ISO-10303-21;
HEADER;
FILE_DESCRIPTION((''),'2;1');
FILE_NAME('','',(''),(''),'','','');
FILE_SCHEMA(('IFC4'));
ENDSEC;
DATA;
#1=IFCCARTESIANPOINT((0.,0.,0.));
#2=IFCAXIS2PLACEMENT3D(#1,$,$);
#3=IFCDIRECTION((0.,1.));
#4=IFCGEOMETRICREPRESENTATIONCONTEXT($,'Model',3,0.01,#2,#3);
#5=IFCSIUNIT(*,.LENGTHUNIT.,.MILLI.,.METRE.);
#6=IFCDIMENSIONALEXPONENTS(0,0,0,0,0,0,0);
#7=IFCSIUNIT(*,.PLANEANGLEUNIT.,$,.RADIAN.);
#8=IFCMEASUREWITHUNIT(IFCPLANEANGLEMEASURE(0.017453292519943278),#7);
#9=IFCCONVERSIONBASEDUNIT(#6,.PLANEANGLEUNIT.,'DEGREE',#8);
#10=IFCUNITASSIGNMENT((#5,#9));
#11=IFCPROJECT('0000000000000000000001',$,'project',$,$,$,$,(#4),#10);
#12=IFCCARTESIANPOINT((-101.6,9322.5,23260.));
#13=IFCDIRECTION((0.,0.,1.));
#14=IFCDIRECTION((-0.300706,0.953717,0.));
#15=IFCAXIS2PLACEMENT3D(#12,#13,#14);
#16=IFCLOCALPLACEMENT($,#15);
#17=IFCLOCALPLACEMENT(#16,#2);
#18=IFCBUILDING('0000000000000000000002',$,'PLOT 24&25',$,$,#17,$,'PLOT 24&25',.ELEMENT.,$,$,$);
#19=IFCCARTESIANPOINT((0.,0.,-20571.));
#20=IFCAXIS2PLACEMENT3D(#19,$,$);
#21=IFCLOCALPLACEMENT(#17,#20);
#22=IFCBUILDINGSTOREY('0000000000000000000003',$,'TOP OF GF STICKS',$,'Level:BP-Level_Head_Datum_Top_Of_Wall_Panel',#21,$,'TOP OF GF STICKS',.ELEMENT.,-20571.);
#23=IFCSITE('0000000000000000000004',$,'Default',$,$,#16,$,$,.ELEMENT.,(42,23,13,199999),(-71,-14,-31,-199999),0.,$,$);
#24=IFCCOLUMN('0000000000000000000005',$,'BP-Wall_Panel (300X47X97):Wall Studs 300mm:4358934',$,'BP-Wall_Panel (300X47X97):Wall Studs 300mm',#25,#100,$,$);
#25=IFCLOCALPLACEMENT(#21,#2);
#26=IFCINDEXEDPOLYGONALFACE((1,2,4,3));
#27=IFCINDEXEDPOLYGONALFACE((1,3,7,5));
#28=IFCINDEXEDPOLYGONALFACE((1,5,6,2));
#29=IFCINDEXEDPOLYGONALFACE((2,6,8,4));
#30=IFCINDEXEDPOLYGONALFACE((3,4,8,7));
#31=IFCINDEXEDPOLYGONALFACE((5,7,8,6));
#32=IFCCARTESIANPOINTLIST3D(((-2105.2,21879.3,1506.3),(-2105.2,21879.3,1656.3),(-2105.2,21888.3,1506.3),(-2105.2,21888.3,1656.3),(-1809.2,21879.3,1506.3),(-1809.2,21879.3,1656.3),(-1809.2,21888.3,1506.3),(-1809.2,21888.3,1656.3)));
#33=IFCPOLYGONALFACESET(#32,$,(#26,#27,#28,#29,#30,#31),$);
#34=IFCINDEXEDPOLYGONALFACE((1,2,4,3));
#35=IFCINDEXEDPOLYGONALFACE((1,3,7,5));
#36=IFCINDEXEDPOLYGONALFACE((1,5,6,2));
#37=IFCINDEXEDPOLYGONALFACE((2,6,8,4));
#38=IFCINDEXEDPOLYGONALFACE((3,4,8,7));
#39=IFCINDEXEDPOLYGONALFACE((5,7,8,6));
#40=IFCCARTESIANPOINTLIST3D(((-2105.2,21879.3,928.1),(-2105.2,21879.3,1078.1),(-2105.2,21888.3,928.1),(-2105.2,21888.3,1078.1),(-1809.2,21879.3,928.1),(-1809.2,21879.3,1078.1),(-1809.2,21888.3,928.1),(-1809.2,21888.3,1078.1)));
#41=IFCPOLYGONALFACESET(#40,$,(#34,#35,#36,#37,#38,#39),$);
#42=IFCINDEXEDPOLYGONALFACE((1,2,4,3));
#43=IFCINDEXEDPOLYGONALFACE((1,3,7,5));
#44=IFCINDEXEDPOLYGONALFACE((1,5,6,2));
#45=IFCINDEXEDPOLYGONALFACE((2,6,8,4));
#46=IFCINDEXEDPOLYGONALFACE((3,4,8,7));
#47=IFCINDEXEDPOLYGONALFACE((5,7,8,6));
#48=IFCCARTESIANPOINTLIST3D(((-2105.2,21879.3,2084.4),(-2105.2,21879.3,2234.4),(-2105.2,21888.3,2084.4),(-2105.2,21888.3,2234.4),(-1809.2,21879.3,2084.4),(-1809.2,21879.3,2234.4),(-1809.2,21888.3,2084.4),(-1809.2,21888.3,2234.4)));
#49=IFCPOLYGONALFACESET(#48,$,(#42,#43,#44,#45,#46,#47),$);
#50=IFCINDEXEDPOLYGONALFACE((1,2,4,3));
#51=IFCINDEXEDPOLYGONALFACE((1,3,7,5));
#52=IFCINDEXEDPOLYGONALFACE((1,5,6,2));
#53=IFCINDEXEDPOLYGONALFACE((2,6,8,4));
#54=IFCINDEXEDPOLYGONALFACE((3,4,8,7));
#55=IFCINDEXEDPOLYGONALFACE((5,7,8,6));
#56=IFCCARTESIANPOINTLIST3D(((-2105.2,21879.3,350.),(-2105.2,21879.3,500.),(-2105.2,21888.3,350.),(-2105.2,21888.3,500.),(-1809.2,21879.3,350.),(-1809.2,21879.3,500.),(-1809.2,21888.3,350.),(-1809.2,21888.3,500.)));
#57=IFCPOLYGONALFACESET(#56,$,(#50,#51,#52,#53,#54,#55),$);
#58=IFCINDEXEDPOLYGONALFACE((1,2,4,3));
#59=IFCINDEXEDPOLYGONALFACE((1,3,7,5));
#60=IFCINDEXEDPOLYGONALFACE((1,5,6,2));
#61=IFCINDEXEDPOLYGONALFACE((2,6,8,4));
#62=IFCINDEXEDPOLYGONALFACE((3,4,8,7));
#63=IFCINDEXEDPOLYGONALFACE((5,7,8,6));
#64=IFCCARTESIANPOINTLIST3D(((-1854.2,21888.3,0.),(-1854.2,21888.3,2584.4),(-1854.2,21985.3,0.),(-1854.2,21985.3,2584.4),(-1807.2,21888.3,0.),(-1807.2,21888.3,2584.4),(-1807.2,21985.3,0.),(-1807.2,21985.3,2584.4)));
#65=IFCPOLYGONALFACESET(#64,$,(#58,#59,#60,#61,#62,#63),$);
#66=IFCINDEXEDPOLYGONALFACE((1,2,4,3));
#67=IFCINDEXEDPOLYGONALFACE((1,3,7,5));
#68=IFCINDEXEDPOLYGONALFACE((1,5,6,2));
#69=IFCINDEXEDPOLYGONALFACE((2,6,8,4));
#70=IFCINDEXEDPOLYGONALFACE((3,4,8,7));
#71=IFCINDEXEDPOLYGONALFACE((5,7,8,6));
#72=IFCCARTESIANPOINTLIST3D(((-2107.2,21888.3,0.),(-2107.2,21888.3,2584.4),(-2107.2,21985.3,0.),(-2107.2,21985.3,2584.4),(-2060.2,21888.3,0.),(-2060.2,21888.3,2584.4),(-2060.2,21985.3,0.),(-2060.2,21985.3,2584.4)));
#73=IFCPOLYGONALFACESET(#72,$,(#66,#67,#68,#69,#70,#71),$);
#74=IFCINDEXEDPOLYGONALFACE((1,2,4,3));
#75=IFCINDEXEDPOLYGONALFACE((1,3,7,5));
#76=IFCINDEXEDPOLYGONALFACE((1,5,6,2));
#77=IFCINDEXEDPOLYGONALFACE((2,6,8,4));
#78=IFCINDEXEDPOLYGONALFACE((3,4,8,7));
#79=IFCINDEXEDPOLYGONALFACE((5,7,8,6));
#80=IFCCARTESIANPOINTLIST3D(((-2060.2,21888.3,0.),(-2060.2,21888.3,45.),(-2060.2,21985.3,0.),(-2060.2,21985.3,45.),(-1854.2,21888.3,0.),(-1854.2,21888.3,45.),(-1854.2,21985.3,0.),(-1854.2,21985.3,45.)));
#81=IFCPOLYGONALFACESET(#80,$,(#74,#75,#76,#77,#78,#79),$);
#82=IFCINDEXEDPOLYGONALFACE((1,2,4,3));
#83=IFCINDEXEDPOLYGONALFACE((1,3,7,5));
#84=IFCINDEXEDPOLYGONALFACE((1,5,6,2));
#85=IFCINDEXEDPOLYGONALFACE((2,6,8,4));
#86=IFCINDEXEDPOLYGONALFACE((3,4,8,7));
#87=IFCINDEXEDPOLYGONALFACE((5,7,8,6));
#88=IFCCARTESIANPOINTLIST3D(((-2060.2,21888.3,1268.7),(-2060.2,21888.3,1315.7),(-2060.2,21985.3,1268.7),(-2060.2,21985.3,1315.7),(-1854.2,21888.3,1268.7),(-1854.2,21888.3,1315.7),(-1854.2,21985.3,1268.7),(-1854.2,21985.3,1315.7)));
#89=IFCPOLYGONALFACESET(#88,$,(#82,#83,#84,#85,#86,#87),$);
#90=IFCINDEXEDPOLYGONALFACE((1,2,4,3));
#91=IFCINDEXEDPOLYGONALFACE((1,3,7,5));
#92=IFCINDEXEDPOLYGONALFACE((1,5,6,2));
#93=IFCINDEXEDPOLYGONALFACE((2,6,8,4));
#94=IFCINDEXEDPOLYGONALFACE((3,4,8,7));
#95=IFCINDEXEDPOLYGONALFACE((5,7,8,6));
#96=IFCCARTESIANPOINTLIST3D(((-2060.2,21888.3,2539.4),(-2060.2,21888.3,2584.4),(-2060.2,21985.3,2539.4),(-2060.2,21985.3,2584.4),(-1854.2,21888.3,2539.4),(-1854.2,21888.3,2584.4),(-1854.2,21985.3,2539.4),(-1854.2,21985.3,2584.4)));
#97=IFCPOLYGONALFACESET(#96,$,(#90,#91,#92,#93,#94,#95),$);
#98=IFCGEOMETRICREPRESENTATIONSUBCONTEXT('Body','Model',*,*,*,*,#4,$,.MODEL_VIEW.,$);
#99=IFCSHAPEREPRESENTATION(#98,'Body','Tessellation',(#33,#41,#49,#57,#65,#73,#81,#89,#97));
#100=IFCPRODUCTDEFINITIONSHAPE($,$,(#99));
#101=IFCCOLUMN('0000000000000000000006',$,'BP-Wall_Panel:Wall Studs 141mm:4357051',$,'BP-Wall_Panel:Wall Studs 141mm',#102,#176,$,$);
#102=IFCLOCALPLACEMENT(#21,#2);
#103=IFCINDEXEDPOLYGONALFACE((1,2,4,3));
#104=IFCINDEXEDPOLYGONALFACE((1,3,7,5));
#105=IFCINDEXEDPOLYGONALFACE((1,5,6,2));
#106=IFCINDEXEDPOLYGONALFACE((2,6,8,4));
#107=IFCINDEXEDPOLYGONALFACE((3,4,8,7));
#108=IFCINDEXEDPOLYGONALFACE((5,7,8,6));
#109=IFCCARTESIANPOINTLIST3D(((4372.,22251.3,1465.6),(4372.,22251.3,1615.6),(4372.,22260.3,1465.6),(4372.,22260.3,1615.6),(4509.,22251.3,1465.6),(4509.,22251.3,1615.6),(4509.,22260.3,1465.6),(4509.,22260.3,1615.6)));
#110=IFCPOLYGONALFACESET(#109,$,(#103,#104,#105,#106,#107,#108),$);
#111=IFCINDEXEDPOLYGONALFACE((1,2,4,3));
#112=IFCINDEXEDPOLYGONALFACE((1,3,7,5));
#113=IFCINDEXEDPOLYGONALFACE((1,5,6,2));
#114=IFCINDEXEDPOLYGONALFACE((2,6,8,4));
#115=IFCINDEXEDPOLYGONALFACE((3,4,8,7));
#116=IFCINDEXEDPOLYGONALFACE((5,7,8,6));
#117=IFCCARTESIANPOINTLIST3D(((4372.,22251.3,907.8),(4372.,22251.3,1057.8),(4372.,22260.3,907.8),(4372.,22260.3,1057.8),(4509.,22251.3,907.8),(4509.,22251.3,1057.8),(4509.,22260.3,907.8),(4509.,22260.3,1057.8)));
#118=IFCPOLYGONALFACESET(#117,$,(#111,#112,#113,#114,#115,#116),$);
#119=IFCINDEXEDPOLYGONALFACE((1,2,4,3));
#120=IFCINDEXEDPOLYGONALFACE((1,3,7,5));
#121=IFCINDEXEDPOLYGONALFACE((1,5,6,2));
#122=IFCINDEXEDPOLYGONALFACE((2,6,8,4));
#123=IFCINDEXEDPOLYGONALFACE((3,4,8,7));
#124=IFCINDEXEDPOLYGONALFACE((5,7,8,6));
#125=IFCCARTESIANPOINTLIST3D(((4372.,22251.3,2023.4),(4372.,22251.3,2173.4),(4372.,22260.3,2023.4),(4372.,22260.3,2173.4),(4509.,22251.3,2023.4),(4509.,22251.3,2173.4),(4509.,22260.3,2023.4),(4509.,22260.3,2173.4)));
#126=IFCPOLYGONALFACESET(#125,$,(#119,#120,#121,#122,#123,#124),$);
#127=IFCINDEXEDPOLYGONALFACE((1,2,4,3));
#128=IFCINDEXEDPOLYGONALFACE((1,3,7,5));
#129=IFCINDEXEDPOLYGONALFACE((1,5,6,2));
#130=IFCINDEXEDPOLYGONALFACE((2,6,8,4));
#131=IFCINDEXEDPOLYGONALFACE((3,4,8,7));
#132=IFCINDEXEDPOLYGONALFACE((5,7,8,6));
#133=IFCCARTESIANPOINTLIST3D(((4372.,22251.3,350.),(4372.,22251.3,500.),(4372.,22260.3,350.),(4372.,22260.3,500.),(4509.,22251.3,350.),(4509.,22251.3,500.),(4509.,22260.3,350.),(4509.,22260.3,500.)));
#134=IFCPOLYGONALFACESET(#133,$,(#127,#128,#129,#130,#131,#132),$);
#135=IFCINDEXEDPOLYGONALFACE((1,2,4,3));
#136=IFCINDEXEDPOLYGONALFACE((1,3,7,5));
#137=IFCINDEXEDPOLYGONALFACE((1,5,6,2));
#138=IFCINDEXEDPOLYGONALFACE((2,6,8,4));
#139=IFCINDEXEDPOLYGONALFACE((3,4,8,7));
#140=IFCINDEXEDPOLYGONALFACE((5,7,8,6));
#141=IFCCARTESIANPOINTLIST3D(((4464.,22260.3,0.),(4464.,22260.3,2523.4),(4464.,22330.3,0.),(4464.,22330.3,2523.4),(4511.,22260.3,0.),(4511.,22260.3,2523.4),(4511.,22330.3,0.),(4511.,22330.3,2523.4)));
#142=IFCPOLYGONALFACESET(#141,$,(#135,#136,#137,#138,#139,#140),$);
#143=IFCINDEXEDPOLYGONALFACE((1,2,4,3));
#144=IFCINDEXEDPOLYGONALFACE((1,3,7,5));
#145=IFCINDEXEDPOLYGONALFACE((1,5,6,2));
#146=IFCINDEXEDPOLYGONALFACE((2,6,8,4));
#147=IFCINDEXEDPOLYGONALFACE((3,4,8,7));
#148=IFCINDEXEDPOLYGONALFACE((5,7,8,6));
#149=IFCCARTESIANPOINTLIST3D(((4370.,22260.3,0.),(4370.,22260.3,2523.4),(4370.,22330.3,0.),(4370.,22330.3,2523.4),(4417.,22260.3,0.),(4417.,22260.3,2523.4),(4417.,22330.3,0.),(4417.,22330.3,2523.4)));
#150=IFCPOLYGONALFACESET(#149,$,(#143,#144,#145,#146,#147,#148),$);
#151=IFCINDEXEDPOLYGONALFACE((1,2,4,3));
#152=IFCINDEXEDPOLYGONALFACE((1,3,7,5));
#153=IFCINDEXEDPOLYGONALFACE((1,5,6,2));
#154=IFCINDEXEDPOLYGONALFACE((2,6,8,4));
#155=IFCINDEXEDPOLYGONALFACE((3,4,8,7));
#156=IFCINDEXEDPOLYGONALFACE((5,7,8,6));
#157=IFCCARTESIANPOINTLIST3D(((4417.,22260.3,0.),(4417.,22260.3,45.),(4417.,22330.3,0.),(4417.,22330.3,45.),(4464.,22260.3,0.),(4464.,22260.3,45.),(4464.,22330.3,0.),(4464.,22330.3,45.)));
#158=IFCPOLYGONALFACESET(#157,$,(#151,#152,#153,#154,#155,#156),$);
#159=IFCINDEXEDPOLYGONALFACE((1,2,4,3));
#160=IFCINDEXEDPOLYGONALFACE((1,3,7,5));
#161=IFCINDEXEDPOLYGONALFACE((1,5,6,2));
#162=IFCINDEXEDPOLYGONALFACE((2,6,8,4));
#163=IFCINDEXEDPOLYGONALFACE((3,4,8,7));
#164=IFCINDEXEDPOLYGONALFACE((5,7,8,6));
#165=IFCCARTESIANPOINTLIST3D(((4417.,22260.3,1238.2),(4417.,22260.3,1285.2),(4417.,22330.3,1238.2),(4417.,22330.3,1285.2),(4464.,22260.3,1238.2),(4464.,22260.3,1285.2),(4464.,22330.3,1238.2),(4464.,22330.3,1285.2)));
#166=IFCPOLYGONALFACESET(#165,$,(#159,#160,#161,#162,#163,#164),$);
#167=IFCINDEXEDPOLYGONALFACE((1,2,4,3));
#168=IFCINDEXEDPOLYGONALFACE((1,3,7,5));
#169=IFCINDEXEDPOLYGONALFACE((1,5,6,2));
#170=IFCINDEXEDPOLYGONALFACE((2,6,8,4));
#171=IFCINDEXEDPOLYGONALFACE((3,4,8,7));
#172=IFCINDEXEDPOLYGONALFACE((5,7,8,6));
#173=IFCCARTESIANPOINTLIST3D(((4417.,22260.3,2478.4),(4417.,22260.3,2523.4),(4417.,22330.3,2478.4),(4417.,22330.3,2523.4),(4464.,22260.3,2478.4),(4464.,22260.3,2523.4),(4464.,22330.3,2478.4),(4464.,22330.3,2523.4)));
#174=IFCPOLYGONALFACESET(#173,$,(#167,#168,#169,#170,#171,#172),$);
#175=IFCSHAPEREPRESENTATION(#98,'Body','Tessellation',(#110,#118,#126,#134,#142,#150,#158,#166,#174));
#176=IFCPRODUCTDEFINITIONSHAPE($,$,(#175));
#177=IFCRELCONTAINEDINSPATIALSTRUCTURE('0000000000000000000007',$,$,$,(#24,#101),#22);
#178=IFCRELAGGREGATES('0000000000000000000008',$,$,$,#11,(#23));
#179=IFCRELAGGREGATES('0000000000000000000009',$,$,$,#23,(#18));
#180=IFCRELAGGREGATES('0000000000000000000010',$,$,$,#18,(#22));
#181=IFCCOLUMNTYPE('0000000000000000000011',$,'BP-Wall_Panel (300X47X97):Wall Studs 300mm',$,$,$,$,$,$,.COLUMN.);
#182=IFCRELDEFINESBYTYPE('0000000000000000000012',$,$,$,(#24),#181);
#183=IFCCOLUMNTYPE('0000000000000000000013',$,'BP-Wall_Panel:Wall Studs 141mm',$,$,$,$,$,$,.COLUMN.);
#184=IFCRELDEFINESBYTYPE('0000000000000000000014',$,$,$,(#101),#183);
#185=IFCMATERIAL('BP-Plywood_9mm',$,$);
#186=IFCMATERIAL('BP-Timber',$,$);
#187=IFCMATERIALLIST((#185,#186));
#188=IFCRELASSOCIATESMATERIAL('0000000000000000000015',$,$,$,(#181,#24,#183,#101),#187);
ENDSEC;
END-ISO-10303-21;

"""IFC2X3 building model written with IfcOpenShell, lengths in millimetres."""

from ifc_helpers import new_model, entity, si_unit, converted_unit, direction, frame, frame_2d, origin, origin_2d_with_axis, place, context, subcontext, project, spatial, rectangle, extrude, source, transform, mapped, material, material_list, type_object, type_shapes, element, save


model = new_model("IFC2X3")

# Units and contexts
model_context = context("Model", 3, precision=0.01, world=origin(), true_north=direction((0.0, 1.0)))
body_context = subcontext(model_context, "Body", "Model", "MODEL_VIEW")
ifc_project = project(units=[si_unit("LENGTHUNIT", "METRE", prefix="MILLI"), converted_unit("PLANEANGLEUNIT", "DEGREE", entity("IfcPlaneAngleMeasure", 0.017453292519943278), si_unit("PLANEANGLEUNIT", "RADIAN"), dimensions=[0, 0, 0, 0, 0, 0, 0])], contexts=[model_context])

# Site, building, storey
site_placement = place(None, frame((-101.6, 9322.5, 23260.0), z_axis=(0.0, 0.0, 1.0), x_axis=(-0.300706, 0.953717, 0.0)))
site = spatial("IfcSite", under=ifc_project, at=site_placement, Name="Default", CompositionType="ELEMENT", RefLatitude=(42, 23, 13, 199999), RefLongitude=(-71, -14, -31, -199999), RefElevation=0.0)
building_placement = place(site_placement, origin())
building = spatial("IfcBuilding", under=site, at=building_placement, Name="PLOT 24&25", LongName="PLOT 24&25", CompositionType="ELEMENT")
storey_placement = place(building_placement, frame((0.0, 0.0, -20571.0)))
storey = spatial("IfcBuildingStorey", under=building, at=storey_placement, Name="TOP OF GF STICKS", ObjectType="Level:BP-Level_Head_Datum_Top_Of_Wall_Panel", LongName="TOP OF GF STICKS", CompositionType="ELEMENT", Elevation=-20571.0)

# Columns
ifc_material_1 = material(Name="BP-Plywood_9mm")
ifc_material_2 = material(Name="BP-Timber")
ifc_material_list = material_list([ifc_material_1, ifc_material_2])
column_type_1 = type_object("IfcColumnType", Name="BP-Wall_Panel (300X47X97):Wall Studs 300mm", PredefinedType="COLUMN", material=ifc_material_list)
shared_shape_1 = source(origin(), body_context, "Body", "SweptSolid", [
    extrude(rectangle(XDim=9.0, YDim=296.0, at=origin_2d_with_axis()), frame((-53.0, 0.0, -19064.7), z_axis=(0.0, 0.0, 1.0), x_axis=(-1.0, 0.0, 0.0)), (0.0, 0.0, 1.0), 150.0),
    extrude(rectangle(XDim=9.0, YDim=296.0, at=origin_2d_with_axis()), frame((-53.0, 0.0, -19642.9), z_axis=(0.0, 0.0, 1.0), x_axis=(-1.0, 0.0, 0.0)), (0.0, 0.0, 1.0), 150.0),
    extrude(rectangle(XDim=9.0, YDim=296.0, at=origin_2d_with_axis()), frame((-53.0, 0.0, -18486.6), z_axis=(0.0, 0.0, 1.0), x_axis=(-1.0, 0.0, 0.0)), (0.0, 0.0, 1.0), 150.0),
    extrude(rectangle(XDim=9.0, YDim=296.0, at=origin_2d_with_axis()), frame((-53.0, 0.0, -20221.0), z_axis=(0.0, 0.0, 1.0), x_axis=(-1.0, 0.0, 0.0)), (0.0, 0.0, 1.0), 150.0),
    extrude(rectangle(XDim=97.0, YDim=47.0, at=origin_2d_with_axis()), frame((0.0, -126.5, -20571.0), z_axis=(0.0, 0.0, 1.0), x_axis=(-1.0, 0.0, 0.0)), (0.0, 0.0, 1.0), 2584.4),
    extrude(rectangle(XDim=97.0, YDim=47.0, at=frame_2d((0.0, 0.0), x_axis=(1.0, 0.0))), frame((0.0, 126.5, -20571.0), z_axis=(0.0, 0.0, 1.0), x_axis=(-1.0, 0.0, 0.0)), (0.0, 0.0, 1.0), 2584.4),
    extrude(rectangle(XDim=206.0, YDim=97.0, at=origin_2d_with_axis()), frame((0.0, 0.0, -20571.0), z_axis=(0.0, 0.0, 1.0), x_axis=(0.0, -1.0, 0.0)), (0.0, 0.0, 1.0), 45.0),
    extrude(rectangle(XDim=206.0, YDim=97.0, at=origin_2d_with_axis()), frame((0.0, 0.0, -19302.3), z_axis=(0.0, 0.0, 1.0), x_axis=(0.0, -1.0, 0.0)), (0.0, 0.0, 1.0), 47.0),
    extrude(rectangle(XDim=206.0, YDim=97.0, at=origin_2d_with_axis()), frame((0.0, 0.0, -18031.6), z_axis=(0.0, 0.0, 1.0), x_axis=(0.0, -1.0, 0.0)), (0.0, 0.0, 1.0), 45.0),
])
type_shapes(column_type_1, [shared_shape_1])
column_1_placement = place(storey_placement, frame((-1957.2, 21936.8, 20571.0), z_axis=(0.0, 0.0, 1.0), x_axis=(0.0, 1.0, 0.0)))
element("IfcColumn", 1, at=column_1_placement, inside=storey, type_object=column_type_1, material=ifc_material_list, Name="BP-Wall_Panel (300X47X97):Wall Studs 300mm:4358934", ObjectType="BP-Wall_Panel (300X47X97):Wall Studs 300mm", context=body_context, shape_type="MappedRepresentation", body=[
    mapped(shared_shape_1, transform((0.0, 0.0, 0.0), scale=1.0)),
])
column_type_2 = type_object("IfcColumnType", Name="BP-Wall_Panel:Wall Studs 141mm", PredefinedType="COLUMN", material=ifc_material_list)
shared_shape_2 = source(origin(), body_context, "Body", "SweptSolid", [
    extrude(rectangle(XDim=9.0, YDim=137.0, at=origin_2d_with_axis()), frame((-39.5, 0.0, -19105.4), z_axis=(0.0, 0.0, 1.0), x_axis=(-1.0, 0.0, 0.0)), (0.0, 0.0, 1.0), 150.0),
    extrude(rectangle(XDim=9.0, YDim=137.0, at=origin_2d_with_axis()), frame((-39.5, 0.0, -19663.2), z_axis=(0.0, 0.0, 1.0), x_axis=(-1.0, 0.0, 0.0)), (0.0, 0.0, 1.0), 150.0),
    extrude(rectangle(XDim=9.0, YDim=137.0, at=origin_2d_with_axis()), frame((-39.5, 0.0, -18547.6), z_axis=(0.0, 0.0, 1.0), x_axis=(-1.0, 0.0, 0.0)), (0.0, 0.0, 1.0), 150.0),
    extrude(rectangle(XDim=9.0, YDim=137.0, at=origin_2d_with_axis()), frame((-39.5, 0.0, -20221.0), z_axis=(0.0, 0.0, 1.0), x_axis=(-1.0, 0.0, 0.0)), (0.0, 0.0, 1.0), 150.0),
    extrude(rectangle(XDim=70.0, YDim=47.0, at=origin_2d_with_axis()), frame((0.0, -47.0, -20571.0), z_axis=(0.0, 0.0, 1.0), x_axis=(-1.0, 0.0, 0.0)), (0.0, 0.0, 1.0), 2523.4),
    extrude(rectangle(XDim=70.0, YDim=47.0, at=origin_2d_with_axis()), frame((0.0, 47.0, -20571.0), z_axis=(0.0, 0.0, 1.0), x_axis=(-1.0, 0.0, 0.0)), (0.0, 0.0, 1.0), 2523.4),
    extrude(rectangle(XDim=47.0, YDim=70.0, at=origin_2d_with_axis()), frame((0.0, 0.0, -20571.0), z_axis=(0.0, 0.0, 1.0), x_axis=(0.0, -1.0, 0.0)), (0.0, 0.0, 1.0), 45.0),
    extrude(rectangle(XDim=47.0, YDim=70.0, at=origin_2d_with_axis()), frame((0.0, 0.0, -19332.8), z_axis=(0.0, 0.0, 1.0), x_axis=(0.0, -1.0, 0.0)), (0.0, 0.0, 1.0), 47.0),
    extrude(rectangle(XDim=47.0, YDim=70.0, at=origin_2d_with_axis()), frame((0.0, 0.0, -18092.6), z_axis=(0.0, 0.0, 1.0), x_axis=(0.0, -1.0, 0.0)), (0.0, 0.0, 1.0), 45.0),
])
type_shapes(column_type_2, [shared_shape_2])
for number, where, z_axis, x_axis, name in (
    (2, (4440.5, 22295.3, 20571.0), (0.0, 0.0, 1.0), (0.0, 1.0, 0.0), "BP-Wall_Panel:Wall Studs 141mm:4357051"),
):
    element("IfcColumn", number, at=place(storey_placement, frame(where, z_axis=z_axis, x_axis=x_axis)), inside=storey, type_object=column_type_2, material=ifc_material_list, Name=name, ObjectType="BP-Wall_Panel:Wall Studs 141mm", context=body_context, shape_type="MappedRepresentation", body=[
        mapped(shared_shape_2, transform((0.0, 0.0, 0.0), scale=1.0)),
    ])

save(model, "model.ifc")
